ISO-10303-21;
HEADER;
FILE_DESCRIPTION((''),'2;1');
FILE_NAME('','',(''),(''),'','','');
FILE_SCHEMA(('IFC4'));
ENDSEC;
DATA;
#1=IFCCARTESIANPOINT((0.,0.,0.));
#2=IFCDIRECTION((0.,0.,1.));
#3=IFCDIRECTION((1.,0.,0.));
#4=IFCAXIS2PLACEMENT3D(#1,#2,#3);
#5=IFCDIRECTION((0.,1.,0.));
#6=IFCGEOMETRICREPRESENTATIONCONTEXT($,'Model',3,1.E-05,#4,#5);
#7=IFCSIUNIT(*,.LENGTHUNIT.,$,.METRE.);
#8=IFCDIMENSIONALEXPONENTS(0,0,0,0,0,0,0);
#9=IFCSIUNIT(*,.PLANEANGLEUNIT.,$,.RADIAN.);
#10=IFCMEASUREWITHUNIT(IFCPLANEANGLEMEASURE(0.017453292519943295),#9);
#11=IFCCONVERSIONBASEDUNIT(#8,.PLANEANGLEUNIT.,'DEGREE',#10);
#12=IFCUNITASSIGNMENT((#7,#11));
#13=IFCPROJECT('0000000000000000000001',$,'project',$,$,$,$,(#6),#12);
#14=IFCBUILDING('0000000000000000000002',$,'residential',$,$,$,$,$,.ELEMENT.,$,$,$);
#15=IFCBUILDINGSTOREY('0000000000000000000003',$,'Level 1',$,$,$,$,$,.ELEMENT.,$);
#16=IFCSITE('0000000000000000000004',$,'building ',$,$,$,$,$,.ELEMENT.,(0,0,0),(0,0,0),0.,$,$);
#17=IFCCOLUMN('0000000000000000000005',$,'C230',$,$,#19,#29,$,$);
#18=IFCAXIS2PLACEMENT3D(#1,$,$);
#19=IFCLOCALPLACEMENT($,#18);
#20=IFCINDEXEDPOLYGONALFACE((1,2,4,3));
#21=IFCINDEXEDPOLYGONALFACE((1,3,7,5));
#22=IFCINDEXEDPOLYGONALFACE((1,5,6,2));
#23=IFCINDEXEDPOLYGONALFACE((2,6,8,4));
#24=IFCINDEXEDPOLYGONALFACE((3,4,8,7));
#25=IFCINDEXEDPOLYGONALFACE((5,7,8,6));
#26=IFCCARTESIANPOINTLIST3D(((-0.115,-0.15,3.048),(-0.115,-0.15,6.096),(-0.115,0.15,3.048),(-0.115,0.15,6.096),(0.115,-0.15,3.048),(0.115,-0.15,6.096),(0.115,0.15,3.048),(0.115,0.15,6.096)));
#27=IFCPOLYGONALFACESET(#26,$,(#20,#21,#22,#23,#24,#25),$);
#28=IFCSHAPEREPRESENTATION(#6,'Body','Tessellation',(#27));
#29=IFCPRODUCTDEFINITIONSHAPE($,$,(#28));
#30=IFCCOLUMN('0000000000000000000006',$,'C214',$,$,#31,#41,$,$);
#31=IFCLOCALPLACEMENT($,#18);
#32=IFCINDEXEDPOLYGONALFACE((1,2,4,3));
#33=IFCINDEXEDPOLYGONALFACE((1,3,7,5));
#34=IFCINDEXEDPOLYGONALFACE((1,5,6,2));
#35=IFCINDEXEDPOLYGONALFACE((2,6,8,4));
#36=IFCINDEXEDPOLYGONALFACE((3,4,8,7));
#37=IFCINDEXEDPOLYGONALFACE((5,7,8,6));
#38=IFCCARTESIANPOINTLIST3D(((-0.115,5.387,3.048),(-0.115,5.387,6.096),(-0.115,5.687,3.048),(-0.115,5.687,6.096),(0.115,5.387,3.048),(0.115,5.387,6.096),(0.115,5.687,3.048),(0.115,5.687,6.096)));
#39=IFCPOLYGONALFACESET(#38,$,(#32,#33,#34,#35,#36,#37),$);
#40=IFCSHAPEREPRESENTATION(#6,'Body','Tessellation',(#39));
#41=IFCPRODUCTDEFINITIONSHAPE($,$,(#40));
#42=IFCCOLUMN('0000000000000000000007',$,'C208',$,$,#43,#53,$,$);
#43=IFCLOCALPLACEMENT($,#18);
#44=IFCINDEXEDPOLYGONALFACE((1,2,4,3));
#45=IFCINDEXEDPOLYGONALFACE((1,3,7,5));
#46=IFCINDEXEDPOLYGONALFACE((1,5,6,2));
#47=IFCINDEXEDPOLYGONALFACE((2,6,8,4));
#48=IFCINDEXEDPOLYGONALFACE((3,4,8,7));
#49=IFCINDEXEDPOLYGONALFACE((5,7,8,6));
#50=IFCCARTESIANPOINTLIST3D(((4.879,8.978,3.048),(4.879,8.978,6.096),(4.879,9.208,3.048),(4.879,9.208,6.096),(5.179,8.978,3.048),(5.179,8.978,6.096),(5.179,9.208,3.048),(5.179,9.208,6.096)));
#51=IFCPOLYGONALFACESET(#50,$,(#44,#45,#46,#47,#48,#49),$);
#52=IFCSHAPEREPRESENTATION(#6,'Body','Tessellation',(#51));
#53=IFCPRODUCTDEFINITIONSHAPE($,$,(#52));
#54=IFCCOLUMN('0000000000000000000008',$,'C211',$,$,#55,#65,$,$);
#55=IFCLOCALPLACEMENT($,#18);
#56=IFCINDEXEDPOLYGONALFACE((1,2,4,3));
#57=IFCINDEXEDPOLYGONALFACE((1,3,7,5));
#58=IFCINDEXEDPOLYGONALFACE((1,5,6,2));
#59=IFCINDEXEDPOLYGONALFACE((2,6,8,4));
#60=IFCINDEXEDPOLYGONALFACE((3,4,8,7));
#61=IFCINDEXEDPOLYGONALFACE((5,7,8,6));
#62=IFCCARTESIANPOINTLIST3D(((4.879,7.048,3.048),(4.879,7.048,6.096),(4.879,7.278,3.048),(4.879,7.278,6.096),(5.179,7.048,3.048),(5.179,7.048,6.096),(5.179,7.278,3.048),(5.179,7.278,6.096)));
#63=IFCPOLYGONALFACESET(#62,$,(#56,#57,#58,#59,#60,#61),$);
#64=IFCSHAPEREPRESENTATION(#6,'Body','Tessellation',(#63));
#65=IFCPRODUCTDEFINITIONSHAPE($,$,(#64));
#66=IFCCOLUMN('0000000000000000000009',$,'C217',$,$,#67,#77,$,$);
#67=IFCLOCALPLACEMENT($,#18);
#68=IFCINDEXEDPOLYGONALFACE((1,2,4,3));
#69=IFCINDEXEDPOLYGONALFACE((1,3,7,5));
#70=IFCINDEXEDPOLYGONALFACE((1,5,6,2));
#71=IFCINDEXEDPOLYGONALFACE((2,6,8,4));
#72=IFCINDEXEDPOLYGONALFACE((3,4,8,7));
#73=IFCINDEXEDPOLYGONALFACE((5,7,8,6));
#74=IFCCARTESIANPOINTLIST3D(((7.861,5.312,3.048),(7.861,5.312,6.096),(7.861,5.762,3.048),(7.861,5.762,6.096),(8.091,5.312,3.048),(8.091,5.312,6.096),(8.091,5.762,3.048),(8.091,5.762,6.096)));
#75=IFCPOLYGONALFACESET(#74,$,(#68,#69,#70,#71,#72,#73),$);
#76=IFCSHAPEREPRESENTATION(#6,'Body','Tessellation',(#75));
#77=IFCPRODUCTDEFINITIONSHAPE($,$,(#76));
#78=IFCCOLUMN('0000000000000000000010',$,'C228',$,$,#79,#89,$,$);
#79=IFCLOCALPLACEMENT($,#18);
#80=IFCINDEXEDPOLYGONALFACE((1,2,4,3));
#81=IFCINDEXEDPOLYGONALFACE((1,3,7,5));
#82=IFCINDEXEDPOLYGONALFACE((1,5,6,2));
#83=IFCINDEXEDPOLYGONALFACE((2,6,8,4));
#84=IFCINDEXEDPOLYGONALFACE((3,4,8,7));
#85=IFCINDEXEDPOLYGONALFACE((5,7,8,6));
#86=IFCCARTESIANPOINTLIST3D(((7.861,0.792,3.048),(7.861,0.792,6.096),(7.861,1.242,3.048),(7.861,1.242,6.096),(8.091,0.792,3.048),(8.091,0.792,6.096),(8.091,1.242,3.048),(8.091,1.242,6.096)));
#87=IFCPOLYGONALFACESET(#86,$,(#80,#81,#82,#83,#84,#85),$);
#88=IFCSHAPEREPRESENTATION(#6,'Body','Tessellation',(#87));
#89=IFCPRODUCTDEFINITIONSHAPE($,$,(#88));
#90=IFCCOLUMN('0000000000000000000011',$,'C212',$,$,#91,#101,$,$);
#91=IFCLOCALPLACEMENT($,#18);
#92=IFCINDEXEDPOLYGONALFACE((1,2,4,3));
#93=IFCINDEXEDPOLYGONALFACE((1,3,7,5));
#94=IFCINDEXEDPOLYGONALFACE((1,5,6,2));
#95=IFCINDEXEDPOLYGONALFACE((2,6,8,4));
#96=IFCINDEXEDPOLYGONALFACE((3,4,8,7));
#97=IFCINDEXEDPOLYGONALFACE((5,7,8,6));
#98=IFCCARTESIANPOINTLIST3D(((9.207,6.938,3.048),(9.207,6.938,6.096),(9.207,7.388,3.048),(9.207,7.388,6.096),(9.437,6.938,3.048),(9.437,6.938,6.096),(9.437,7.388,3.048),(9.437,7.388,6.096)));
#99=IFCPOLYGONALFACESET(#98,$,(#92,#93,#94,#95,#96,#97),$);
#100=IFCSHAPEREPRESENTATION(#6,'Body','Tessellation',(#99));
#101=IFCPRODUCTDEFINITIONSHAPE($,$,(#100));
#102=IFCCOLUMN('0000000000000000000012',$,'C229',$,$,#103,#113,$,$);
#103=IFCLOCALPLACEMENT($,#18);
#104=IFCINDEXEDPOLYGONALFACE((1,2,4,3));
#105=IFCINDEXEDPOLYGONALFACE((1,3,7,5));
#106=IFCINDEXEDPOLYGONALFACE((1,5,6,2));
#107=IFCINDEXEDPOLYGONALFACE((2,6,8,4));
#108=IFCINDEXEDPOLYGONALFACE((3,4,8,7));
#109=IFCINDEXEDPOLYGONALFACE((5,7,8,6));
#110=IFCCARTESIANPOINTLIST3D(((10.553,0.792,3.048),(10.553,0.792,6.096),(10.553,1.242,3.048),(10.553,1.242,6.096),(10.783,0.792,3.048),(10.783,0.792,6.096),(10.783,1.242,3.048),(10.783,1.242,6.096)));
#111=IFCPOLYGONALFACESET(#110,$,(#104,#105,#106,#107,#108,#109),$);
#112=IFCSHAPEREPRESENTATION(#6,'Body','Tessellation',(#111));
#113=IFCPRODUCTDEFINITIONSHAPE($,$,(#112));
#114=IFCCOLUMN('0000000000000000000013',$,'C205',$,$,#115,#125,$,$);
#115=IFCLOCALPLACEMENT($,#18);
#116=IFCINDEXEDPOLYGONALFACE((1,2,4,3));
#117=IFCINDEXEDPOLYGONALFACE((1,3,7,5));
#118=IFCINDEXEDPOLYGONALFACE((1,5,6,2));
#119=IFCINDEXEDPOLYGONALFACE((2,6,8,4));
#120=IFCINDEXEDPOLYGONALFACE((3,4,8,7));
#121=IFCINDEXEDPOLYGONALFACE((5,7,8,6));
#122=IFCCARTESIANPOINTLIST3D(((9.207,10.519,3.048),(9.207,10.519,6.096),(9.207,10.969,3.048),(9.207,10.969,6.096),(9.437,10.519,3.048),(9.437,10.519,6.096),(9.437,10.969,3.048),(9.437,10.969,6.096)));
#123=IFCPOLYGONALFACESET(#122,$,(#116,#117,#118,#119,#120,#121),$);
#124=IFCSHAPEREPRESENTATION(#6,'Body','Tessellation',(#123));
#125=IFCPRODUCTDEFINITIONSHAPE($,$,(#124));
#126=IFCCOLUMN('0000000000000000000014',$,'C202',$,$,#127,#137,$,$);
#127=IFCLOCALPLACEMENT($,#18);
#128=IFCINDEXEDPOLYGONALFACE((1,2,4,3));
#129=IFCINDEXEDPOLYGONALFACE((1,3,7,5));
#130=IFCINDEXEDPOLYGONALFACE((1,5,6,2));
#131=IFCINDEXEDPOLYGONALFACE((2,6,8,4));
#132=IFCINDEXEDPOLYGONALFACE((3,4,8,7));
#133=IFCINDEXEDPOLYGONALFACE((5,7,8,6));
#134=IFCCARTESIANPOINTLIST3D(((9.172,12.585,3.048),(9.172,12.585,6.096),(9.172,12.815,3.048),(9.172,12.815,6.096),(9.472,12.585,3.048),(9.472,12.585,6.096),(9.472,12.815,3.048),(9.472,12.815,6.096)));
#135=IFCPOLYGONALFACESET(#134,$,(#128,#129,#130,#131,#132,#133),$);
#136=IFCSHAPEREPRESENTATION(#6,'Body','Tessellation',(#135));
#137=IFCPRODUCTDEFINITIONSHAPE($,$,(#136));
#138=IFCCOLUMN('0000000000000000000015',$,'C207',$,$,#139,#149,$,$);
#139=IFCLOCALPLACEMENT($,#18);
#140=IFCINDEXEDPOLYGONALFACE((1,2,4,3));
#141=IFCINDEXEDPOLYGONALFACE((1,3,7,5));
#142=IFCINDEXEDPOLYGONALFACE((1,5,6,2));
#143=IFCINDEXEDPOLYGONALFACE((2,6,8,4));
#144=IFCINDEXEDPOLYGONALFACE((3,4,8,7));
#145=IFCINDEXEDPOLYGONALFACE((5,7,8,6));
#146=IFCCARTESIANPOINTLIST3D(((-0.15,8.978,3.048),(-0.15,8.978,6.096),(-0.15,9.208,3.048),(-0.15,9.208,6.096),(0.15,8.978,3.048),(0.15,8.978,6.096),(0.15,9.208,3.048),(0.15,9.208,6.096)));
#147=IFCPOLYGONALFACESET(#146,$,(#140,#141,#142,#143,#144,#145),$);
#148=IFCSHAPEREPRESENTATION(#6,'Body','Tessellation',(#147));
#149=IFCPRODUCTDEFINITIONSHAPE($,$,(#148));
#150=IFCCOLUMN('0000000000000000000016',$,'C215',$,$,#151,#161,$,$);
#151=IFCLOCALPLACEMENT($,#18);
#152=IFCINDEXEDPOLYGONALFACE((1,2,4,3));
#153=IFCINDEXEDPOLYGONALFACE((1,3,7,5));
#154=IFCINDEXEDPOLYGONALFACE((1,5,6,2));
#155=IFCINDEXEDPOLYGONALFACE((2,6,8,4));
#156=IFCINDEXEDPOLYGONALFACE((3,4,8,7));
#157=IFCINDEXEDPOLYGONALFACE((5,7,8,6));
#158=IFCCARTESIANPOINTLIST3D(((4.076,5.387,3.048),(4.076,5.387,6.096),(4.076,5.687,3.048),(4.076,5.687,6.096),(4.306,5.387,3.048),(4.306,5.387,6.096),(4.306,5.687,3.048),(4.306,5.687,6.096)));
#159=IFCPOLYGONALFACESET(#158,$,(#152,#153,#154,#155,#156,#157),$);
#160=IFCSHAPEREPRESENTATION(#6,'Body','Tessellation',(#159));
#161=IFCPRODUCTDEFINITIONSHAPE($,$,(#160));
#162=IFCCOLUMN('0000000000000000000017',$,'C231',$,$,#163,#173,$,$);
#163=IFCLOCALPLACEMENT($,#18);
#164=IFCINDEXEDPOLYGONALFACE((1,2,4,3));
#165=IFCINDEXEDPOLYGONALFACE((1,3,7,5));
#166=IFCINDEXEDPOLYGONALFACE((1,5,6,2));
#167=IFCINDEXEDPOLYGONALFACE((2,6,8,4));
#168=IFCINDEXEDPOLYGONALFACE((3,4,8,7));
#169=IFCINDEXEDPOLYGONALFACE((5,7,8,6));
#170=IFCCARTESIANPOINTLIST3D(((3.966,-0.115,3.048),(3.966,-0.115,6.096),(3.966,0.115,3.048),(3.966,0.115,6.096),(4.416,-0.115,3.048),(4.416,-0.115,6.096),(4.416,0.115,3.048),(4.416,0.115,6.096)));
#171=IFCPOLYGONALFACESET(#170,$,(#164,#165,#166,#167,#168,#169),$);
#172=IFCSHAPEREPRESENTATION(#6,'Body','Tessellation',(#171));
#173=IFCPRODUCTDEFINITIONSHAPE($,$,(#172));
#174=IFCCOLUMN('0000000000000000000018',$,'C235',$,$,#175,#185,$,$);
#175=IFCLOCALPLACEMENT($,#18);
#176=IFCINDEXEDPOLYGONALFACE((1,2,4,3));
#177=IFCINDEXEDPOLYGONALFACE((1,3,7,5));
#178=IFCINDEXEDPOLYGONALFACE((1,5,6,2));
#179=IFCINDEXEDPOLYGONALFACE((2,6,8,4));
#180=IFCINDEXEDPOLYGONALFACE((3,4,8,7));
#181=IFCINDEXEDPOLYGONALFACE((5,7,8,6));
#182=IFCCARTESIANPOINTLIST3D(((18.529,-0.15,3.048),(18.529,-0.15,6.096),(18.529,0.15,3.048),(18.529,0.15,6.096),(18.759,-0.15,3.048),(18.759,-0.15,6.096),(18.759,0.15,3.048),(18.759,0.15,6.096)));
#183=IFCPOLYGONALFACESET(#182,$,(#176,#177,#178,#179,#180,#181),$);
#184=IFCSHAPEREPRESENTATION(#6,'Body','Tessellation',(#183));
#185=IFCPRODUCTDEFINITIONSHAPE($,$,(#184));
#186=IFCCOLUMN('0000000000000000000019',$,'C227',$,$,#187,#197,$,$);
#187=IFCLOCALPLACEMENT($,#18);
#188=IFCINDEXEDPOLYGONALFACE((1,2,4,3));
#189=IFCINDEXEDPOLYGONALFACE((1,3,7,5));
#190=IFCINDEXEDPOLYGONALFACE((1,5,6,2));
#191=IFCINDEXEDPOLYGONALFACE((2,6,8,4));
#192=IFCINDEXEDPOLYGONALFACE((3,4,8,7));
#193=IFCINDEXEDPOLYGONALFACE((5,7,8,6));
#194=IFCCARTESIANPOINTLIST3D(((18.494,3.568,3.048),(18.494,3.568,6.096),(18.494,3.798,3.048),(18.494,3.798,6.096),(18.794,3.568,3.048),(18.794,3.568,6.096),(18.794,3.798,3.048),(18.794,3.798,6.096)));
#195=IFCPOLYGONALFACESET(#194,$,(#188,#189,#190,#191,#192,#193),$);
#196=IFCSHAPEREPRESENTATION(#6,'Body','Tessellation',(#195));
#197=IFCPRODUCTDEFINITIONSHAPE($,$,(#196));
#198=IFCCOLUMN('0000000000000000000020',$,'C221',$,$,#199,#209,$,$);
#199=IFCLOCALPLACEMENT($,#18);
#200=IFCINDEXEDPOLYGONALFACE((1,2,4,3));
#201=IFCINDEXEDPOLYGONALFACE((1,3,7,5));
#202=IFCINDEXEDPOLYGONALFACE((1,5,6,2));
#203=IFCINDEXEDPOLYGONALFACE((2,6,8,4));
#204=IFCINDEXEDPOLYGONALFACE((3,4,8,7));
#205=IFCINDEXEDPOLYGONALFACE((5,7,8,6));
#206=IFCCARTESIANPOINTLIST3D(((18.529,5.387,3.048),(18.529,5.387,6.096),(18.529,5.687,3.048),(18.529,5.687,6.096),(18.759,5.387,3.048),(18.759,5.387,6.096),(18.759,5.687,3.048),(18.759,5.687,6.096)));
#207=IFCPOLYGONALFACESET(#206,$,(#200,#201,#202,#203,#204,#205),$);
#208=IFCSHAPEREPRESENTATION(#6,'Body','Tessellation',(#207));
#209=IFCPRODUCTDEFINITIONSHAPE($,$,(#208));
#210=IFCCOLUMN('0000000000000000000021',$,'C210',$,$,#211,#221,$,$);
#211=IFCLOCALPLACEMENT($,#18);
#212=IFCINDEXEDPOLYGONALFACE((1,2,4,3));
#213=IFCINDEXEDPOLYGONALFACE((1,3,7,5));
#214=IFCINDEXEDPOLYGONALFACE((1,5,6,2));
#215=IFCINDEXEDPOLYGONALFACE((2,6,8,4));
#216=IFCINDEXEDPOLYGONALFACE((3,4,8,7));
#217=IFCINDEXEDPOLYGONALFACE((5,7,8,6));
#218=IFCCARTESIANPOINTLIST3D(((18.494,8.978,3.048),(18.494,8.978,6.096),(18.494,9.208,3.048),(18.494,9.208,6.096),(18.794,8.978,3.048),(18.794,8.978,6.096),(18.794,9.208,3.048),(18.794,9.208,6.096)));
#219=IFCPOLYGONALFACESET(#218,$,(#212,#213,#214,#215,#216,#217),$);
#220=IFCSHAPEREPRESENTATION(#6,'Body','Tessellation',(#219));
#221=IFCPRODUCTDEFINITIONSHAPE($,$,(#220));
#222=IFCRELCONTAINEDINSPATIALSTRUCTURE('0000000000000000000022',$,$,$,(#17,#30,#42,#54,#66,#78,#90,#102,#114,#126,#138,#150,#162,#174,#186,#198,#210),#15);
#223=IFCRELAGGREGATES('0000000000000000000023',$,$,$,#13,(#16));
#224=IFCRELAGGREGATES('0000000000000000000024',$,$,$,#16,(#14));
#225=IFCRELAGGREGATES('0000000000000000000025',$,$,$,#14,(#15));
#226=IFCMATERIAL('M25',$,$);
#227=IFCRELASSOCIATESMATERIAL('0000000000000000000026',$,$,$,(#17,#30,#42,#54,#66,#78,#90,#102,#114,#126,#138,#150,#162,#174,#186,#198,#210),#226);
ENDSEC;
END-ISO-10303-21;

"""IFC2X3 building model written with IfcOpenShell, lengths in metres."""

from ifc_helpers import new_model, entity, si_unit, converted_unit, direction, frame, frame_2d, origin_with_axes, place, context, project, spatial, rectangle, extrude, material, element, save


model = new_model("IFC2X3")

# Units and contexts
model_context = context("Model", 3, precision=1e-05, world=origin_with_axes(), true_north=direction((0.0, 1.0, 0.0)))
ifc_project = project(units=[si_unit("LENGTHUNIT", "METRE"), converted_unit("PLANEANGLEUNIT", "DEGREE", entity("IfcPlaneAngleMeasure", 0.017453292519943295), si_unit("PLANEANGLEUNIT", "RADIAN"), dimensions=[0, 0, 0, 0, 0, 0, 0])], contexts=[model_context])

# Site, building, storey
site = spatial("IfcSite", under=ifc_project, Name="building ", CompositionType="ELEMENT", RefLatitude=(0, 0, 0), RefLongitude=(0, 0, 0), RefElevation=0.0)
building = spatial("IfcBuilding", under=site, Name="residential", CompositionType="ELEMENT")
storey = spatial("IfcBuildingStorey", under=building, Name="Level 1", CompositionType="ELEMENT")

# Columns
ifc_material = material(Name="M25")
placement = place(None, origin_with_axes())
element("IfcColumn", 1, at=placement, inside=storey, material=ifc_material, Name="C230", context=model_context, shape_type="SweptSolid", body=[
    extrude(rectangle(XDim=0.23, YDim=0.3, at=frame_2d((0.0, 0.0), x_axis=(1.0, 0.0, 0.0))), frame((0.0, 0.0, 3.048), z_axis=(0.0, 0.0, 1.0), x_axis=(1.0, 0.0, 0.0)), (0.0, 0.0, 1.0), 3.048),
])
element("IfcColumn", 2, at=placement, inside=storey, material=ifc_material, Name="C214", context=model_context, shape_type="SweptSolid", body=[
    extrude(rectangle(XDim=0.23, YDim=0.3, at=frame_2d((0.0, 0.0), x_axis=(1.0, 0.0, 0.0))), frame((0.0, 5.537, 3.048), z_axis=(0.0, 0.0, 1.0), x_axis=(1.0, 0.0, 0.0)), (0.0, 0.0, 1.0), 3.048),
])
element("IfcColumn", 3, at=placement, inside=storey, material=ifc_material, Name="C208", context=model_context, shape_type="SweptSolid", body=[
    extrude(rectangle(XDim=0.3, YDim=0.23, at=frame_2d((0.0, 0.0), x_axis=(1.0, 0.0, 0.0))), frame((5.029, 9.093, 3.048), z_axis=(0.0, 0.0, 1.0), x_axis=(1.0, 0.0, 0.0)), (0.0, 0.0, 1.0), 3.048),
])
element("IfcColumn", 4, at=placement, inside=storey, material=ifc_material, Name="C211", context=model_context, shape_type="SweptSolid", body=[
    extrude(rectangle(XDim=0.3, YDim=0.23, at=frame_2d((0.0, 0.0), x_axis=(1.0, 0.0, 0.0))), frame((5.029, 7.163, 3.048), z_axis=(0.0, 0.0, 1.0), x_axis=(1.0, 0.0, 0.0)), (0.0, 0.0, 1.0), 3.048),
])
element("IfcColumn", 5, at=placement, inside=storey, material=ifc_material, Name="C217", context=model_context, shape_type="SweptSolid", body=[
    extrude(rectangle(XDim=0.23, YDim=0.45, at=frame_2d((0.0, 0.0), x_axis=(1.0, 0.0, 0.0))), frame((7.976, 5.537, 3.048), z_axis=(0.0, 0.0, 1.0), x_axis=(1.0, 0.0, 0.0)), (0.0, 0.0, 1.0), 3.048),
])
element("IfcColumn", 6, at=placement, inside=storey, material=ifc_material, Name="C228", context=model_context, shape_type="SweptSolid", body=[
    extrude(rectangle(XDim=0.23, YDim=0.45, at=frame_2d((0.0, 0.0), x_axis=(1.0, 0.0, 0.0))), frame((7.976, 1.017, 3.048), z_axis=(0.0, 0.0, 1.0), x_axis=(1.0, 0.0, 0.0)), (0.0, 0.0, 1.0), 3.048),
])
element("IfcColumn", 7, at=placement, inside=storey, material=ifc_material, Name="C212", context=model_context, shape_type="SweptSolid", body=[
    extrude(rectangle(XDim=0.23, YDim=0.45, at=frame_2d((0.0, 0.0), x_axis=(1.0, 0.0, 0.0))), frame((9.322, 7.163, 3.048), z_axis=(0.0, 0.0, 1.0), x_axis=(1.0, 0.0, 0.0)), (0.0, 0.0, 1.0), 3.048),
])
element("IfcColumn", 8, at=placement, inside=storey, material=ifc_material, Name="C229", context=model_context, shape_type="SweptSolid", body=[
    extrude(rectangle(XDim=0.23, YDim=0.45, at=frame_2d((0.0, 0.0), x_axis=(1.0, 0.0, 0.0))), frame((10.668, 1.017, 3.048), z_axis=(0.0, 0.0, 1.0), x_axis=(1.0, 0.0, 0.0)), (0.0, 0.0, 1.0), 3.048),
])
element("IfcColumn", 9, at=placement, inside=storey, material=ifc_material, Name="C205", context=model_context, shape_type="SweptSolid", body=[
    extrude(rectangle(XDim=0.23, YDim=0.45, at=frame_2d((0.0, 0.0), x_axis=(1.0, 0.0, 0.0))), frame((9.322, 10.744, 3.048), z_axis=(0.0, 0.0, 1.0), x_axis=(1.0, 0.0, 0.0)), (0.0, 0.0, 1.0), 3.048),
])
element("IfcColumn", 10, at=placement, inside=storey, material=ifc_material, Name="C202", context=model_context, shape_type="SweptSolid", body=[
    extrude(rectangle(XDim=0.3, YDim=0.23, at=frame_2d((0.0, 0.0), x_axis=(1.0, 0.0, 0.0))), frame((9.322, 12.7, 3.048), z_axis=(0.0, 0.0, 1.0), x_axis=(1.0, 0.0, 0.0)), (0.0, 0.0, 1.0), 3.048),
])
element("IfcColumn", 11, at=placement, inside=storey, material=ifc_material, Name="C207", context=model_context, shape_type="SweptSolid", body=[
    extrude(rectangle(XDim=0.3, YDim=0.23, at=frame_2d((0.0, 0.0), x_axis=(1.0, 0.0, 0.0))), frame((0.0, 9.093, 3.048), z_axis=(0.0, 0.0, 1.0), x_axis=(1.0, 0.0, 0.0)), (0.0, 0.0, 1.0), 3.048),
])
element("IfcColumn", 12, at=placement, inside=storey, material=ifc_material, Name="C215", context=model_context, shape_type="SweptSolid", body=[
    extrude(rectangle(XDim=0.23, YDim=0.3, at=frame_2d((0.0, 0.0), x_axis=(1.0, 0.0, 0.0))), frame((4.191, 5.537, 3.048), z_axis=(0.0, 0.0, 1.0), x_axis=(1.0, 0.0, 0.0)), (0.0, 0.0, 1.0), 3.048),
])
element("IfcColumn", 13, at=placement, inside=storey, material=ifc_material, Name="C231", context=model_context, shape_type="SweptSolid", body=[
    extrude(rectangle(XDim=0.45, YDim=0.23, at=frame_2d((0.0, 0.0), x_axis=(1.0, 0.0, 0.0))), frame((4.191, 0.0, 3.048), z_axis=(0.0, 0.0, 1.0), x_axis=(1.0, 0.0, 0.0)), (0.0, 0.0, 1.0), 3.048),
])
element("IfcColumn", 14, at=placement, inside=storey, material=ifc_material, Name="C235", context=model_context, shape_type="SweptSolid", body=[
    extrude(rectangle(XDim=0.23, YDim=0.3, at=frame_2d((0.0, 0.0), x_axis=(1.0, 0.0, 0.0))), frame((18.644, 0.0, 3.048), z_axis=(0.0, 0.0, 1.0), x_axis=(1.0, 0.0, 0.0)), (0.0, 0.0, 1.0), 3.048),
])
element("IfcColumn", 15, at=placement, inside=storey, material=ifc_material, Name="C227", context=model_context, shape_type="SweptSolid", body=[
    extrude(rectangle(XDim=0.3, YDim=0.23, at=frame_2d((0.0, 0.0), x_axis=(1.0, 0.0, 0.0))), frame((18.644, 3.683, 3.048), z_axis=(0.0, 0.0, 1.0), x_axis=(1.0, 0.0, 0.0)), (0.0, 0.0, 1.0), 3.048),
])
element("IfcColumn", 16, at=placement, inside=storey, material=ifc_material, Name="C221", context=model_context, shape_type="SweptSolid", body=[
    extrude(rectangle(XDim=0.23, YDim=0.3, at=frame_2d((0.0, 0.0), x_axis=(1.0, 0.0, 0.0))), frame((18.644, 5.537, 3.048), z_axis=(0.0, 0.0, 1.0), x_axis=(1.0, 0.0, 0.0)), (0.0, 0.0, 1.0), 3.048),
])
element("IfcColumn", 17, at=placement, inside=storey, material=ifc_material, Name="C210", context=model_context, shape_type="SweptSolid", body=[
    extrude(rectangle(XDim=0.3, YDim=0.23, at=frame_2d((0.0, 0.0), x_axis=(1.0, 0.0, 0.0))), frame((18.644, 9.093, 3.048), z_axis=(0.0, 0.0, 1.0), x_axis=(1.0, 0.0, 0.0)), (0.0, 0.0, 1.0), 3.048),
])

save(model, "model.ifc")
